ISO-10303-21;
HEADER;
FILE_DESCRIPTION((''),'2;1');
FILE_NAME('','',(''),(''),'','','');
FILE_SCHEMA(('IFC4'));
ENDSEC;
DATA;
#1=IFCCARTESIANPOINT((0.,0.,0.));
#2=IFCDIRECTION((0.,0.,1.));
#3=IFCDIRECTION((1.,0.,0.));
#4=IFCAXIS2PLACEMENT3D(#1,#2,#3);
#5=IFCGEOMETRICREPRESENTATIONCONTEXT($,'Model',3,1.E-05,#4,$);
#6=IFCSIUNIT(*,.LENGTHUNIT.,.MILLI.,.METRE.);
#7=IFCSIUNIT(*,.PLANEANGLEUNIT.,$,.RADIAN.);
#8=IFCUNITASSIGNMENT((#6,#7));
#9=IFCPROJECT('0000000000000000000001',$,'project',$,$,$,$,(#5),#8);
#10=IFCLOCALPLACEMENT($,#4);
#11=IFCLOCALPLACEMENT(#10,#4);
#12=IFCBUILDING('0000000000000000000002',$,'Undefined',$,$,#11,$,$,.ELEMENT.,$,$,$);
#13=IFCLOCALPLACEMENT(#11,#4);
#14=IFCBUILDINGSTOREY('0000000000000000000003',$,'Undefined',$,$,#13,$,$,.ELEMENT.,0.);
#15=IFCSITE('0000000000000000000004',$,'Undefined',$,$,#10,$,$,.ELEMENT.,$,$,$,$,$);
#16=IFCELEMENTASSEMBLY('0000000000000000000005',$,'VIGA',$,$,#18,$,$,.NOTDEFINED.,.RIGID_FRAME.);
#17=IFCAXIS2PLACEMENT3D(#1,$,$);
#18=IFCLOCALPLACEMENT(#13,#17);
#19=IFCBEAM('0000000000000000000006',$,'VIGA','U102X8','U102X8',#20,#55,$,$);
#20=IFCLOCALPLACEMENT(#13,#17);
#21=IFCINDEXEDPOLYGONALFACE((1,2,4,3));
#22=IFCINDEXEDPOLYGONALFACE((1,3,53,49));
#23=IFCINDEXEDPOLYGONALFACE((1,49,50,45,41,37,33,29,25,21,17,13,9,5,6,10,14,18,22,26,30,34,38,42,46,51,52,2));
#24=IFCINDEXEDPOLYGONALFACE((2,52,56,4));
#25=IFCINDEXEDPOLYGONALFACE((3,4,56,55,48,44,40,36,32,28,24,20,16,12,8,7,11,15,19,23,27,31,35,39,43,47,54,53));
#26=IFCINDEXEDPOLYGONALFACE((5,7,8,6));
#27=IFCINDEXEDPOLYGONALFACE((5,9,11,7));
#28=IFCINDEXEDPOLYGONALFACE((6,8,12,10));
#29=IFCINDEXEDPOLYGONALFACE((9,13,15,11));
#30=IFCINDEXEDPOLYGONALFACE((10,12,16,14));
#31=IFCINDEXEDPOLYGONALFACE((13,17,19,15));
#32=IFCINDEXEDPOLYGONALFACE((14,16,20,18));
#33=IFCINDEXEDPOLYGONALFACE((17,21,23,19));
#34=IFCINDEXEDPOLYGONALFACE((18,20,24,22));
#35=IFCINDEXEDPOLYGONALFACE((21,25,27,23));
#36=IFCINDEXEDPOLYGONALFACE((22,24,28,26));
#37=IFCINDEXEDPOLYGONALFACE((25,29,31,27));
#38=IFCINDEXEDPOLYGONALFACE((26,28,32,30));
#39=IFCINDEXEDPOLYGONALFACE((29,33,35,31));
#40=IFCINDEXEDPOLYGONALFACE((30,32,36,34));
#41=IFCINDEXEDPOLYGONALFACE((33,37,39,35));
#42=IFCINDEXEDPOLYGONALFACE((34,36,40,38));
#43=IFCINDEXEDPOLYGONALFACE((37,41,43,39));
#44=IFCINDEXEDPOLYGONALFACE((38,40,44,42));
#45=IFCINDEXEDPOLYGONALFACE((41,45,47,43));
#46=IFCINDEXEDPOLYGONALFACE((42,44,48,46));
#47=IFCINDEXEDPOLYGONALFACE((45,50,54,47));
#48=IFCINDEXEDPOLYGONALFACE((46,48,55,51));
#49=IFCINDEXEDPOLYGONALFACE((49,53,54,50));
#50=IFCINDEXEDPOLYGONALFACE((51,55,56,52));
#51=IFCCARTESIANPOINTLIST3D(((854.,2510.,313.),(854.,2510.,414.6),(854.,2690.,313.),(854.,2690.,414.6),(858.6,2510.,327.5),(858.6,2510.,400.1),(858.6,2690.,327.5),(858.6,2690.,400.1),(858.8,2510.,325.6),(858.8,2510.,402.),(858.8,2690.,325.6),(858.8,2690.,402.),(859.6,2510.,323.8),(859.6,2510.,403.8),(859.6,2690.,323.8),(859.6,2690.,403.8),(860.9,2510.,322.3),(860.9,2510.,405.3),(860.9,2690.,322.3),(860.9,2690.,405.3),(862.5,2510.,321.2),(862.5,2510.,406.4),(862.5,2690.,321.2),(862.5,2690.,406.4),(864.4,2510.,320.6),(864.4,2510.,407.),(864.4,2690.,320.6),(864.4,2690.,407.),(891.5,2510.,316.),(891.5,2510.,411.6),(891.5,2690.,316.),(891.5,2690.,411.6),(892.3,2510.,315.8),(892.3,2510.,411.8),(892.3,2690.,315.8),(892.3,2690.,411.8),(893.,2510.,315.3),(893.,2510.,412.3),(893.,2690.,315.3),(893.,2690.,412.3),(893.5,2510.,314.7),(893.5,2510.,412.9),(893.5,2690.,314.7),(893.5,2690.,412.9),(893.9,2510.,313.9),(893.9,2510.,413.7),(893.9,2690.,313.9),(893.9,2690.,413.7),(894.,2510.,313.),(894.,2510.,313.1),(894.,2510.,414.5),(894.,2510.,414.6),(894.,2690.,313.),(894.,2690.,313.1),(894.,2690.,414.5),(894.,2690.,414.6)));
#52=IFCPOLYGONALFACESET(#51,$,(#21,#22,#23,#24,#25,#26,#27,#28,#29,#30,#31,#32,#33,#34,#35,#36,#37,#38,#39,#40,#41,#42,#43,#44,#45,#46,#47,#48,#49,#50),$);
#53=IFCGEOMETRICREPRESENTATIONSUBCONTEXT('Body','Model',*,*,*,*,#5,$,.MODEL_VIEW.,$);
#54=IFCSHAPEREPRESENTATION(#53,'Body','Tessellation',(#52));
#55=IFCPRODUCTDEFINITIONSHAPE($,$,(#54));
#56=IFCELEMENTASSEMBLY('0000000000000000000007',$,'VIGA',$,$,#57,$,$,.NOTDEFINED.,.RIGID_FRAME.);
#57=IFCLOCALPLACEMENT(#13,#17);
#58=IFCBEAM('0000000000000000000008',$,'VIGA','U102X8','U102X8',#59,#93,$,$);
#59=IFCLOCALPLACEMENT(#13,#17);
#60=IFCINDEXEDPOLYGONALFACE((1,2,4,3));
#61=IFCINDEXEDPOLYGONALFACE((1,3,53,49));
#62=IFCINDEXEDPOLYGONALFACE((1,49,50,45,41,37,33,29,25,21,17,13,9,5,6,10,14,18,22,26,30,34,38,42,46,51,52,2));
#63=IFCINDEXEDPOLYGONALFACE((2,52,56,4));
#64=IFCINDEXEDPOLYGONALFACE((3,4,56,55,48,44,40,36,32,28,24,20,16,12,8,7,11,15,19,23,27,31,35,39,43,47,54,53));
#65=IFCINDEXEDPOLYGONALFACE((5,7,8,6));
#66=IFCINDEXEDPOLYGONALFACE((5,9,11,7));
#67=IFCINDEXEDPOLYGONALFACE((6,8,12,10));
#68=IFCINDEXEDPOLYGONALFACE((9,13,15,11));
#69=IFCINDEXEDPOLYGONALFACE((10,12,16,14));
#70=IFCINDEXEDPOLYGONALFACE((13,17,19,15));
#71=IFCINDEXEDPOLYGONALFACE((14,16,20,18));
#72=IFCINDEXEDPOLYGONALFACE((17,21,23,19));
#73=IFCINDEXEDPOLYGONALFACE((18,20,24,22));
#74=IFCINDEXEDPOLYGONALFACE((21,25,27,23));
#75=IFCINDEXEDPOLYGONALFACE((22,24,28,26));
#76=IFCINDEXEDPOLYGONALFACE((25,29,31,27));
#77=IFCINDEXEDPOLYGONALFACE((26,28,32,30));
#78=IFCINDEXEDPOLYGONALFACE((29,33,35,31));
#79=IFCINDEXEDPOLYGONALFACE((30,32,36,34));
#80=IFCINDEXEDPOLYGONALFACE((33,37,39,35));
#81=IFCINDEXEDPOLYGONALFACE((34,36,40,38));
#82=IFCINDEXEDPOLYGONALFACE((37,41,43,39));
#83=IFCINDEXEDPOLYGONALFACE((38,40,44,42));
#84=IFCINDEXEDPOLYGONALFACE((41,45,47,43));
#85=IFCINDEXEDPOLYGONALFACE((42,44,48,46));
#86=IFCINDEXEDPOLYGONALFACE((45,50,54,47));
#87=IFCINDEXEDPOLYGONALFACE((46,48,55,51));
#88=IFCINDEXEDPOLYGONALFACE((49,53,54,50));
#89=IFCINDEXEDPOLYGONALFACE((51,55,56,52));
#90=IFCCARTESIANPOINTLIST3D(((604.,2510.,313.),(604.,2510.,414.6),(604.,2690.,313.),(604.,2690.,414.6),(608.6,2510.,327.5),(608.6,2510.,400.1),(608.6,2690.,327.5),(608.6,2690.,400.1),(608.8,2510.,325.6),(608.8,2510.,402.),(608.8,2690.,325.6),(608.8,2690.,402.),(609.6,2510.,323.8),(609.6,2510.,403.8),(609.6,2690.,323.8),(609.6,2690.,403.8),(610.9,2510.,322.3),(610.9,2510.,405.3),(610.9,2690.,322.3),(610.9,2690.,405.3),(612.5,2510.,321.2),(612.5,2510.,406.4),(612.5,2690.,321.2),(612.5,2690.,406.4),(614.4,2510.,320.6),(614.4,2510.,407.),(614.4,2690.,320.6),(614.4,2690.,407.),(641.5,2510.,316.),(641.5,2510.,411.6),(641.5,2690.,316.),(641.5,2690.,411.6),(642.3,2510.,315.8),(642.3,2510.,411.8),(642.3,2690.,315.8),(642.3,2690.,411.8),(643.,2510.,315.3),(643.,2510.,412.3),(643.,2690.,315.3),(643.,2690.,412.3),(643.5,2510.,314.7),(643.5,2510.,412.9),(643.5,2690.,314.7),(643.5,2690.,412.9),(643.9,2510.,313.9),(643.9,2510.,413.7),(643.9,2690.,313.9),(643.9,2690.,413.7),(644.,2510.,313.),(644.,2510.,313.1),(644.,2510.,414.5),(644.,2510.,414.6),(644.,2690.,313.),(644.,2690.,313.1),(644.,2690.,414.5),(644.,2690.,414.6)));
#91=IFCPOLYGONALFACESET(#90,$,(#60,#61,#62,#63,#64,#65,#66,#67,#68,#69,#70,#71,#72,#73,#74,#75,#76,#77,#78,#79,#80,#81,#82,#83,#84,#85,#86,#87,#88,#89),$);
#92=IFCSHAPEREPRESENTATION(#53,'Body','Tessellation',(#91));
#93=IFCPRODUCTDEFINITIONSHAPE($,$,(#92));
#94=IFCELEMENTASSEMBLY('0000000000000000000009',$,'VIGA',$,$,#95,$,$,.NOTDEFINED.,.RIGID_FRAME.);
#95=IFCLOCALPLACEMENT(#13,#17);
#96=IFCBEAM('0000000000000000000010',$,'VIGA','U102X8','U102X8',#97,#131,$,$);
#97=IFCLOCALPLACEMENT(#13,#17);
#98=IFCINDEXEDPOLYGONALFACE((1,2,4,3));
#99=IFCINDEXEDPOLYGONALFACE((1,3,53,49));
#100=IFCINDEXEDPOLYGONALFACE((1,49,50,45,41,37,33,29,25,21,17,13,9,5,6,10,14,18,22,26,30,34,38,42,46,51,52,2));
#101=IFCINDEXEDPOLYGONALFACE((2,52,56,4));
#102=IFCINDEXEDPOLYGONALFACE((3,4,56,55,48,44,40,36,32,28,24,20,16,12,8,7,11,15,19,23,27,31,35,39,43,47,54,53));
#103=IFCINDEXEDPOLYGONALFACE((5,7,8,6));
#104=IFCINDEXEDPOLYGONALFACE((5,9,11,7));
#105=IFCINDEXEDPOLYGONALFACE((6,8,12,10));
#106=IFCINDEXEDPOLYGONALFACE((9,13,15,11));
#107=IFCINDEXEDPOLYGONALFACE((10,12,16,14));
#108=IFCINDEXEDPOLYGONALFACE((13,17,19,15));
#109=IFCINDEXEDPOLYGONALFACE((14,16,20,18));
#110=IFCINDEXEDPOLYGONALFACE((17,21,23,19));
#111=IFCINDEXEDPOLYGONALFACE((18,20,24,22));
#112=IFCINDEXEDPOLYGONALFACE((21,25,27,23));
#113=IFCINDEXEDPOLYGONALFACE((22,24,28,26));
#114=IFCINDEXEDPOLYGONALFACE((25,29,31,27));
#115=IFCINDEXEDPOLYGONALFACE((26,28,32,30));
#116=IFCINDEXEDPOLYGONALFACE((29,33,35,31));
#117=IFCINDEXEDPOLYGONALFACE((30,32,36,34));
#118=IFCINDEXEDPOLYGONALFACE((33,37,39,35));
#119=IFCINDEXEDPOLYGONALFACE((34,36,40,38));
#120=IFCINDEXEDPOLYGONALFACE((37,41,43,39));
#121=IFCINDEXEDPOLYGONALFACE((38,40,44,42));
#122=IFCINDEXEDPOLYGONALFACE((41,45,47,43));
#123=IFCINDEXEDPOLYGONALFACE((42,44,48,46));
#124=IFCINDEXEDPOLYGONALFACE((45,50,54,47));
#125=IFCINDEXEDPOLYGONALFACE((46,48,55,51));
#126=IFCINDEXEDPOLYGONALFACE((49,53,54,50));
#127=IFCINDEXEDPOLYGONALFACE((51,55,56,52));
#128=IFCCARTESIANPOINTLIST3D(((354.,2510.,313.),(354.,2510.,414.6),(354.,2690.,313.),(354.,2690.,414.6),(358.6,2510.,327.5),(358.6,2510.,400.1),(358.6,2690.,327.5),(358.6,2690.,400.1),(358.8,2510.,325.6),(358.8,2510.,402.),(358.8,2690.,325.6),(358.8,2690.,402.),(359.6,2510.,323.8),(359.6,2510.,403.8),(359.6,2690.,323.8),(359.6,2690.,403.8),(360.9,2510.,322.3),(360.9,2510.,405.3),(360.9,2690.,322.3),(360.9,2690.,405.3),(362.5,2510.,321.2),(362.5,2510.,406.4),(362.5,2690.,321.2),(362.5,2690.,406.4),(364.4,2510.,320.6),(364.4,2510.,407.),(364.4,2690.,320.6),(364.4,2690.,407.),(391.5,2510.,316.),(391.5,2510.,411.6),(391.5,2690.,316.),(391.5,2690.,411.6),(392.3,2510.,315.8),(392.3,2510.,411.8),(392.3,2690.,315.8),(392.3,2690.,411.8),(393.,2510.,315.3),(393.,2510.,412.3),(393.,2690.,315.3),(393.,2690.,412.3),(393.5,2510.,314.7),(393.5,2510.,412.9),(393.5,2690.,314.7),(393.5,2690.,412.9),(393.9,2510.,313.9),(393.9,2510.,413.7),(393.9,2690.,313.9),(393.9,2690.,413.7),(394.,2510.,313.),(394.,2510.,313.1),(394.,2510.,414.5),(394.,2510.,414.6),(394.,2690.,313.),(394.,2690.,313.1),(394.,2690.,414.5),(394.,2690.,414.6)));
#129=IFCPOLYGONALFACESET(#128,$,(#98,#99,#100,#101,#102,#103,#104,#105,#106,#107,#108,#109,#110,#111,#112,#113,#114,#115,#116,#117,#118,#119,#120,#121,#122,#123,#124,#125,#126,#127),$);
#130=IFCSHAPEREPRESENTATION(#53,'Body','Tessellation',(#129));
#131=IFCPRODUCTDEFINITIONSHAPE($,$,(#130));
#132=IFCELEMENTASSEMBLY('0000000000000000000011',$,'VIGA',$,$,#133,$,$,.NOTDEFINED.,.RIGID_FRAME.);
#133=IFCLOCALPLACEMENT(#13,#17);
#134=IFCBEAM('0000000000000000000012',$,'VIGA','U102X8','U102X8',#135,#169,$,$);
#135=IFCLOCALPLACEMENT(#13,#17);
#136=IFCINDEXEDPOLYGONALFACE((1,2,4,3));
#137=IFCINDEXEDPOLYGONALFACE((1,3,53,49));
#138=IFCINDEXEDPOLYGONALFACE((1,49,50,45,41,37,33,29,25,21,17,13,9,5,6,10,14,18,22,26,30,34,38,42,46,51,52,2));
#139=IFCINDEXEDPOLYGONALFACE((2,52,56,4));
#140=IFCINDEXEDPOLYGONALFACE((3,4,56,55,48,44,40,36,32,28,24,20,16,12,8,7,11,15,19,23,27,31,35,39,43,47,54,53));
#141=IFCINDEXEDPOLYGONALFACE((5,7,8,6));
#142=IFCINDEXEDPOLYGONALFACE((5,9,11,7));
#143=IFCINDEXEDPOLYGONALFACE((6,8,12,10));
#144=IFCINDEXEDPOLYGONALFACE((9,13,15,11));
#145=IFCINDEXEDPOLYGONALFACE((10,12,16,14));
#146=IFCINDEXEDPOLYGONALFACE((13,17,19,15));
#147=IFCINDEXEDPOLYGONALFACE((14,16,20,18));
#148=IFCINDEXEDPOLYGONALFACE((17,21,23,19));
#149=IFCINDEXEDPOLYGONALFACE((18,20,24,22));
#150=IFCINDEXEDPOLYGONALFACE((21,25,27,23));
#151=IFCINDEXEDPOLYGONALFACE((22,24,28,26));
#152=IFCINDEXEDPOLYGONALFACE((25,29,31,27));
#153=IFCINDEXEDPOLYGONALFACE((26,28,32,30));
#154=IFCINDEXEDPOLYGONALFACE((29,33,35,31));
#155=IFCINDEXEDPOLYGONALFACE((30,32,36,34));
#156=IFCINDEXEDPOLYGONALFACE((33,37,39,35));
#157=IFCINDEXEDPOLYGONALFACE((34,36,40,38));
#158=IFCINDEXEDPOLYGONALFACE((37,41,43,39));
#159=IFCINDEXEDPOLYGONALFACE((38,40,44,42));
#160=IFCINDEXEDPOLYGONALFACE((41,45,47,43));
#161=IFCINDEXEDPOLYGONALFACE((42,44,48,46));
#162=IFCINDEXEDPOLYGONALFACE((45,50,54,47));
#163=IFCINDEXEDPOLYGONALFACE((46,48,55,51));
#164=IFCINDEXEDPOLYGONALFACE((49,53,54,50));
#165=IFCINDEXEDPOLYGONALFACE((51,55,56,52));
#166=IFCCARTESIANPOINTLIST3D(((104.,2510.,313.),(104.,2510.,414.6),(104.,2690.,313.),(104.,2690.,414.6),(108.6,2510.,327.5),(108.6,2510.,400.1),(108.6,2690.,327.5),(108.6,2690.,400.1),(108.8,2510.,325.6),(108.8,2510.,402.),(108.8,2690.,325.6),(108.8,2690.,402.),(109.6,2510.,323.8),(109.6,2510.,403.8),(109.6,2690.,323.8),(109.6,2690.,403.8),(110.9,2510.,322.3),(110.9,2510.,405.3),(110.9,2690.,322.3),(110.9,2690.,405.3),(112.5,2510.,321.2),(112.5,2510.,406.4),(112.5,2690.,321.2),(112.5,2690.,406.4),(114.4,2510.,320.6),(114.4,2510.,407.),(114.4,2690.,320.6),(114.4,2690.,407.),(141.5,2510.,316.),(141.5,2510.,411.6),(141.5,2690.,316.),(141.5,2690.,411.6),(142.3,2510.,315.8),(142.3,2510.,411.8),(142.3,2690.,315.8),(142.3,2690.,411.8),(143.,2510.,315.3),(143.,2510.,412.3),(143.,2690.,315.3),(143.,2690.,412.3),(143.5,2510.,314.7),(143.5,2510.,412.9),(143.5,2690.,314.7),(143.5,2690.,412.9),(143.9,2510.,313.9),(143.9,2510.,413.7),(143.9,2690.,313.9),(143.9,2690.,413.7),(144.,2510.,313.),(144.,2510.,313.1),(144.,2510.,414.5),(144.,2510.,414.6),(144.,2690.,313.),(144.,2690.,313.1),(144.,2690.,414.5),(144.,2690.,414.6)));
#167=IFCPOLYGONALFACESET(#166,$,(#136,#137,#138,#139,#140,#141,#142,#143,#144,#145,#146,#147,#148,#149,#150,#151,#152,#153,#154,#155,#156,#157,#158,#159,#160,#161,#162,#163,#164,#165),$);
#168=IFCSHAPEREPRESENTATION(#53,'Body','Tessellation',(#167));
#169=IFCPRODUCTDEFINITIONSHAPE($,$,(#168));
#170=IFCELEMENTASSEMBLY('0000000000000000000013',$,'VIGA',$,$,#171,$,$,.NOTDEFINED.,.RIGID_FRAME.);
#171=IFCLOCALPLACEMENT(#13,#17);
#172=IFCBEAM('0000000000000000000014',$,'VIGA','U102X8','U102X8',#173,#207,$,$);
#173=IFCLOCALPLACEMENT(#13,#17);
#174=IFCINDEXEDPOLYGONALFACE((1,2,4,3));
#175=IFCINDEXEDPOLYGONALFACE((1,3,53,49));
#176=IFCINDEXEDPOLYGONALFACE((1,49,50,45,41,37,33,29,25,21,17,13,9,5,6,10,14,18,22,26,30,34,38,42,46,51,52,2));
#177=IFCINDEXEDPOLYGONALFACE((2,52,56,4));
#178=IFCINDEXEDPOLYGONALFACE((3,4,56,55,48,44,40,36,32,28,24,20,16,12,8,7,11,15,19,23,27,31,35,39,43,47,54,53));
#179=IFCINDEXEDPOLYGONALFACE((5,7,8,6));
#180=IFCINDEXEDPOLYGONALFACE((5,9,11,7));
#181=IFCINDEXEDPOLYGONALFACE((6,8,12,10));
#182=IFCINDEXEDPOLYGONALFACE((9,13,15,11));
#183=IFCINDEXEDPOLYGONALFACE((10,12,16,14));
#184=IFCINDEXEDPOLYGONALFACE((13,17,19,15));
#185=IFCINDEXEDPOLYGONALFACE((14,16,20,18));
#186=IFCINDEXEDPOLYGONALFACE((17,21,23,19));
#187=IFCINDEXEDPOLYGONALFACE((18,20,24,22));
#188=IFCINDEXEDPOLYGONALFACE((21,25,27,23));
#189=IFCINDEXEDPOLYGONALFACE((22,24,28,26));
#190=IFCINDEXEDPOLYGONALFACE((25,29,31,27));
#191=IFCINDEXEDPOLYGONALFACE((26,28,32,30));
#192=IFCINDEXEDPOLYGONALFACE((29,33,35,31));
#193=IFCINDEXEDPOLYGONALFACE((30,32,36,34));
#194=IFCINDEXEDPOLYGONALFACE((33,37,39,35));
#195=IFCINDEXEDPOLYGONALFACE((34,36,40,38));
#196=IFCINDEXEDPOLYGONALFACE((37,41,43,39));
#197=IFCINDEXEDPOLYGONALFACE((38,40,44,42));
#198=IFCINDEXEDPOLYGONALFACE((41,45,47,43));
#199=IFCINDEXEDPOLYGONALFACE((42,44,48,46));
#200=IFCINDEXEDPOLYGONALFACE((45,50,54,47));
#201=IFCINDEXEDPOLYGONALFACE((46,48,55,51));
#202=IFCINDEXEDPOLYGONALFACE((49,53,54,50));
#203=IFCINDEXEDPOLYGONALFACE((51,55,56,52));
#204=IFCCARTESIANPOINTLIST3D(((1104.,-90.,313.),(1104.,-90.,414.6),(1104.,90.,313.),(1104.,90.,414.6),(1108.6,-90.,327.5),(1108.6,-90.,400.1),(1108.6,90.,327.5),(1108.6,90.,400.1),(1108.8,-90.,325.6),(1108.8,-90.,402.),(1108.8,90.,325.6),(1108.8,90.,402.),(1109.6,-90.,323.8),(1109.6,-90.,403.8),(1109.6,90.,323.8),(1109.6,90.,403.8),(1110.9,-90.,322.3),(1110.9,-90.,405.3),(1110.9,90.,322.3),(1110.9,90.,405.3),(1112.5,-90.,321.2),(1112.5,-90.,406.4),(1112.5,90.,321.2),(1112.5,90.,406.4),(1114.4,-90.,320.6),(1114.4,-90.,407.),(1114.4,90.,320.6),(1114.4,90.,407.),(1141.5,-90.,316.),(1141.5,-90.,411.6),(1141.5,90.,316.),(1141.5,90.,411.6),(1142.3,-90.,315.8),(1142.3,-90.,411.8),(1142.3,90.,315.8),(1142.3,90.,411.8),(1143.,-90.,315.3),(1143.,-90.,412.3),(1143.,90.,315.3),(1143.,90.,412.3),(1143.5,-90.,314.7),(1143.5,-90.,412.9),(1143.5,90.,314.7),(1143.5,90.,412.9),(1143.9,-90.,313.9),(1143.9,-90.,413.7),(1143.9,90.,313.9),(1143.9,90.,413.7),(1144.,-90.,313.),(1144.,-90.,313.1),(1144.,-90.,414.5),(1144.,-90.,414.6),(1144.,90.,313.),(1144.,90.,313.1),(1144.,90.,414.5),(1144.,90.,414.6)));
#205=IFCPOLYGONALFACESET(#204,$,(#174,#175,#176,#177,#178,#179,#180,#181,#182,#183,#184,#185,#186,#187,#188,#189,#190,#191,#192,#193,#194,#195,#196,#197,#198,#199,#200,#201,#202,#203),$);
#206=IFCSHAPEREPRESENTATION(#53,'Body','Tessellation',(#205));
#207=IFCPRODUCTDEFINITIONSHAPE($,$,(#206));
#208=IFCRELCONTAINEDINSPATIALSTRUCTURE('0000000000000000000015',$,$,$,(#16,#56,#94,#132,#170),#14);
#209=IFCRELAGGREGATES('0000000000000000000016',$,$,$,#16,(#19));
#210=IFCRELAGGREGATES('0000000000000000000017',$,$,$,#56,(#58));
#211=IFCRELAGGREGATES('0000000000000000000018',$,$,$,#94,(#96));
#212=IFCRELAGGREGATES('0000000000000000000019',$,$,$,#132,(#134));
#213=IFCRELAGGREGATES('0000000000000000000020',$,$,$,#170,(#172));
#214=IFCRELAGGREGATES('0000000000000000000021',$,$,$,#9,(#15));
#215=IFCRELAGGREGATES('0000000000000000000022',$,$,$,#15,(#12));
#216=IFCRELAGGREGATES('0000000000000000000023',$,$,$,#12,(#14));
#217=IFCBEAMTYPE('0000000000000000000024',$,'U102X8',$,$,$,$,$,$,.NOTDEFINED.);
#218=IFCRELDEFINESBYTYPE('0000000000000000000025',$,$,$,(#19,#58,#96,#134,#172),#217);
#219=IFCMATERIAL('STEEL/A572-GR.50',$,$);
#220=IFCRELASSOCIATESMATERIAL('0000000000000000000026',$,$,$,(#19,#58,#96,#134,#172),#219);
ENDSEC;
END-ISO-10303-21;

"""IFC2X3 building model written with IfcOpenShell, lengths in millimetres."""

from ifc_helpers import new_model, si_unit, frame, origin_with_axes, origin_2d_with_axis, place, context, subcontext, project, spatial, u_section, extrude, material, type_object, element, aggregate, save


model = new_model("IFC2X3")

# Units and contexts
model_context = context("Model", 3, precision=1e-05, world=origin_with_axes())
body_context = subcontext(model_context, "Body", "Model", "MODEL_VIEW")
ifc_project = project(units=[si_unit("LENGTHUNIT", "METRE", prefix="MILLI"), si_unit("PLANEANGLEUNIT", "RADIAN")], contexts=[model_context])

# Site, building, storey
site_placement = place(None, origin_with_axes())
site = spatial("IfcSite", under=ifc_project, at=site_placement, Name="Undefined", CompositionType="ELEMENT")
building_placement = place(site_placement, origin_with_axes())
building = spatial("IfcBuilding", under=site, at=building_placement, Name="Undefined", CompositionType="ELEMENT")
storey_placement = place(building_placement, origin_with_axes())
storey = spatial("IfcBuildingStorey", under=building, at=storey_placement, Name="Undefined", CompositionType="ELEMENT", Elevation=0.0)

# Element assemblies, beams
ifc_material_1 = material(Name="STEEL/A572-GR.50")
beam_type_1 = type_object("IfcBeamType", Name="U102X8", PredefinedType="NOTDEFINED")
assembly_1_placement = place(storey_placement, origin_with_axes())
assembly_1 = element("IfcElementAssembly", 1, at=assembly_1_placement, inside=storey, Name="VIGA", AssemblyPlace="NOTDEFINED", PredefinedType="RIGID_FRAME")
beam_1_placement = place(assembly_1_placement, frame((874.0, 2510.0, 363.8), z_axis=(0.0, 0.0, 1.0), x_axis=(0.0, 1.0, 0.0)))
beam_1 = element("IfcBeam", 2, at=beam_1_placement, type_object=beam_type_1, material=ifc_material_1, Name="VIGA", Description="U102X8", ObjectType="U102X8", context=body_context, shape_type="SweptSolid", body=[
    extrude(u_section(Depth=101.6, FlangeWidth=40.0, WebThickness=4.6, FlangeThickness=6.0, FilletRadius=7.0, EdgeRadius=3.0, FlangeSlope=0.16839, at=origin_2d_with_axis()), frame((180.0, 0.0, 0.0), z_axis=(-1.0, 0.0, 0.0), x_axis=(0.0, -1.0, 0.0)), (0.0, 0.0, 1.0), 180.0),
])
aggregate(assembly_1, [beam_1])
assembly_2_placement = place(storey_placement, origin_with_axes())
assembly_2 = element("IfcElementAssembly", 3, at=assembly_2_placement, inside=storey, Name="VIGA", AssemblyPlace="NOTDEFINED", PredefinedType="RIGID_FRAME")
beam_2_placement = place(assembly_2_placement, frame((624.0, 2510.0, 363.8), z_axis=(0.0, 0.0, 1.0), x_axis=(0.0, 1.0, 0.0)))
beam_2 = element("IfcBeam", 4, at=beam_2_placement, type_object=beam_type_1, material=ifc_material_1, Name="VIGA", Description="U102X8", ObjectType="U102X8", context=body_context, shape_type="SweptSolid", body=[
    extrude(u_section(Depth=101.6, FlangeWidth=40.0, WebThickness=4.6, FlangeThickness=6.0, FilletRadius=7.0, EdgeRadius=3.0, FlangeSlope=0.16839, at=origin_2d_with_axis()), frame((180.0, 0.0, 0.0), z_axis=(-1.0, 0.0, 0.0), x_axis=(0.0, -1.0, 0.0)), (0.0, 0.0, 1.0), 180.0),
])
aggregate(assembly_2, [beam_2])
assembly_3_placement = place(storey_placement, origin_with_axes())
assembly_3 = element("IfcElementAssembly", 5, at=assembly_3_placement, inside=storey, Name="VIGA", AssemblyPlace="NOTDEFINED", PredefinedType="RIGID_FRAME")
beam_3_placement = place(assembly_3_placement, frame((374.0, 2510.0, 363.8), z_axis=(0.0, 0.0, 1.0), x_axis=(0.0, 1.0, 0.0)))
beam_3 = element("IfcBeam", 6, at=beam_3_placement, type_object=beam_type_1, material=ifc_material_1, Name="VIGA", Description="U102X8", ObjectType="U102X8", context=body_context, shape_type="SweptSolid", body=[
    extrude(u_section(Depth=101.6, FlangeWidth=40.0, WebThickness=4.6, FlangeThickness=6.0, FilletRadius=7.0, EdgeRadius=3.0, FlangeSlope=0.16839, at=origin_2d_with_axis()), frame((180.0, 0.0, 0.0), z_axis=(-1.0, 0.0, 0.0), x_axis=(0.0, -1.0, 0.0)), (0.0, 0.0, 1.0), 180.0),
])
aggregate(assembly_3, [beam_3])
assembly_4_placement = place(storey_placement, origin_with_axes())
assembly_4 = element("IfcElementAssembly", 7, at=assembly_4_placement, inside=storey, Name="VIGA", AssemblyPlace="NOTDEFINED", PredefinedType="RIGID_FRAME")
beam_4_placement = place(assembly_4_placement, frame((124.0, 2510.0, 363.8), z_axis=(0.0, 0.0, 1.0), x_axis=(0.0, 1.0, 0.0)))
beam_4 = element("IfcBeam", 8, at=beam_4_placement, type_object=beam_type_1, material=ifc_material_1, Name="VIGA", Description="U102X8", ObjectType="U102X8", context=body_context, shape_type="SweptSolid", body=[
    extrude(u_section(Depth=101.6, FlangeWidth=40.0, WebThickness=4.6, FlangeThickness=6.0, FilletRadius=7.0, EdgeRadius=3.0, FlangeSlope=0.16839, at=origin_2d_with_axis()), frame((180.0, 0.0, 0.0), z_axis=(-1.0, 0.0, 0.0), x_axis=(0.0, -1.0, 0.0)), (0.0, 0.0, 1.0), 180.0),
])
aggregate(assembly_4, [beam_4])
assembly_5_placement = place(storey_placement, origin_with_axes())
assembly_5 = element("IfcElementAssembly", 9, at=assembly_5_placement, inside=storey, Name="VIGA", AssemblyPlace="NOTDEFINED", PredefinedType="RIGID_FRAME")
beam_5_placement = place(assembly_5_placement, frame((1124.0, -90.0, 363.8), z_axis=(0.0, 0.0, 1.0), x_axis=(0.0, 1.0, 0.0)))
beam_5 = element("IfcBeam", 10, at=beam_5_placement, type_object=beam_type_1, material=ifc_material_1, Name="VIGA", Description="U102X8", ObjectType="U102X8", context=body_context, shape_type="SweptSolid", body=[
    extrude(u_section(Depth=101.6, FlangeWidth=40.0, WebThickness=4.6, FlangeThickness=6.0, FilletRadius=7.0, EdgeRadius=3.0, FlangeSlope=0.16839, at=origin_2d_with_axis()), frame((180.0, 0.0, 0.0), z_axis=(-1.0, 0.0, 0.0), x_axis=(0.0, -1.0, 0.0)), (0.0, 0.0, 1.0), 180.0),
])
aggregate(assembly_5, [beam_5])

save(model, "model.ifc")
